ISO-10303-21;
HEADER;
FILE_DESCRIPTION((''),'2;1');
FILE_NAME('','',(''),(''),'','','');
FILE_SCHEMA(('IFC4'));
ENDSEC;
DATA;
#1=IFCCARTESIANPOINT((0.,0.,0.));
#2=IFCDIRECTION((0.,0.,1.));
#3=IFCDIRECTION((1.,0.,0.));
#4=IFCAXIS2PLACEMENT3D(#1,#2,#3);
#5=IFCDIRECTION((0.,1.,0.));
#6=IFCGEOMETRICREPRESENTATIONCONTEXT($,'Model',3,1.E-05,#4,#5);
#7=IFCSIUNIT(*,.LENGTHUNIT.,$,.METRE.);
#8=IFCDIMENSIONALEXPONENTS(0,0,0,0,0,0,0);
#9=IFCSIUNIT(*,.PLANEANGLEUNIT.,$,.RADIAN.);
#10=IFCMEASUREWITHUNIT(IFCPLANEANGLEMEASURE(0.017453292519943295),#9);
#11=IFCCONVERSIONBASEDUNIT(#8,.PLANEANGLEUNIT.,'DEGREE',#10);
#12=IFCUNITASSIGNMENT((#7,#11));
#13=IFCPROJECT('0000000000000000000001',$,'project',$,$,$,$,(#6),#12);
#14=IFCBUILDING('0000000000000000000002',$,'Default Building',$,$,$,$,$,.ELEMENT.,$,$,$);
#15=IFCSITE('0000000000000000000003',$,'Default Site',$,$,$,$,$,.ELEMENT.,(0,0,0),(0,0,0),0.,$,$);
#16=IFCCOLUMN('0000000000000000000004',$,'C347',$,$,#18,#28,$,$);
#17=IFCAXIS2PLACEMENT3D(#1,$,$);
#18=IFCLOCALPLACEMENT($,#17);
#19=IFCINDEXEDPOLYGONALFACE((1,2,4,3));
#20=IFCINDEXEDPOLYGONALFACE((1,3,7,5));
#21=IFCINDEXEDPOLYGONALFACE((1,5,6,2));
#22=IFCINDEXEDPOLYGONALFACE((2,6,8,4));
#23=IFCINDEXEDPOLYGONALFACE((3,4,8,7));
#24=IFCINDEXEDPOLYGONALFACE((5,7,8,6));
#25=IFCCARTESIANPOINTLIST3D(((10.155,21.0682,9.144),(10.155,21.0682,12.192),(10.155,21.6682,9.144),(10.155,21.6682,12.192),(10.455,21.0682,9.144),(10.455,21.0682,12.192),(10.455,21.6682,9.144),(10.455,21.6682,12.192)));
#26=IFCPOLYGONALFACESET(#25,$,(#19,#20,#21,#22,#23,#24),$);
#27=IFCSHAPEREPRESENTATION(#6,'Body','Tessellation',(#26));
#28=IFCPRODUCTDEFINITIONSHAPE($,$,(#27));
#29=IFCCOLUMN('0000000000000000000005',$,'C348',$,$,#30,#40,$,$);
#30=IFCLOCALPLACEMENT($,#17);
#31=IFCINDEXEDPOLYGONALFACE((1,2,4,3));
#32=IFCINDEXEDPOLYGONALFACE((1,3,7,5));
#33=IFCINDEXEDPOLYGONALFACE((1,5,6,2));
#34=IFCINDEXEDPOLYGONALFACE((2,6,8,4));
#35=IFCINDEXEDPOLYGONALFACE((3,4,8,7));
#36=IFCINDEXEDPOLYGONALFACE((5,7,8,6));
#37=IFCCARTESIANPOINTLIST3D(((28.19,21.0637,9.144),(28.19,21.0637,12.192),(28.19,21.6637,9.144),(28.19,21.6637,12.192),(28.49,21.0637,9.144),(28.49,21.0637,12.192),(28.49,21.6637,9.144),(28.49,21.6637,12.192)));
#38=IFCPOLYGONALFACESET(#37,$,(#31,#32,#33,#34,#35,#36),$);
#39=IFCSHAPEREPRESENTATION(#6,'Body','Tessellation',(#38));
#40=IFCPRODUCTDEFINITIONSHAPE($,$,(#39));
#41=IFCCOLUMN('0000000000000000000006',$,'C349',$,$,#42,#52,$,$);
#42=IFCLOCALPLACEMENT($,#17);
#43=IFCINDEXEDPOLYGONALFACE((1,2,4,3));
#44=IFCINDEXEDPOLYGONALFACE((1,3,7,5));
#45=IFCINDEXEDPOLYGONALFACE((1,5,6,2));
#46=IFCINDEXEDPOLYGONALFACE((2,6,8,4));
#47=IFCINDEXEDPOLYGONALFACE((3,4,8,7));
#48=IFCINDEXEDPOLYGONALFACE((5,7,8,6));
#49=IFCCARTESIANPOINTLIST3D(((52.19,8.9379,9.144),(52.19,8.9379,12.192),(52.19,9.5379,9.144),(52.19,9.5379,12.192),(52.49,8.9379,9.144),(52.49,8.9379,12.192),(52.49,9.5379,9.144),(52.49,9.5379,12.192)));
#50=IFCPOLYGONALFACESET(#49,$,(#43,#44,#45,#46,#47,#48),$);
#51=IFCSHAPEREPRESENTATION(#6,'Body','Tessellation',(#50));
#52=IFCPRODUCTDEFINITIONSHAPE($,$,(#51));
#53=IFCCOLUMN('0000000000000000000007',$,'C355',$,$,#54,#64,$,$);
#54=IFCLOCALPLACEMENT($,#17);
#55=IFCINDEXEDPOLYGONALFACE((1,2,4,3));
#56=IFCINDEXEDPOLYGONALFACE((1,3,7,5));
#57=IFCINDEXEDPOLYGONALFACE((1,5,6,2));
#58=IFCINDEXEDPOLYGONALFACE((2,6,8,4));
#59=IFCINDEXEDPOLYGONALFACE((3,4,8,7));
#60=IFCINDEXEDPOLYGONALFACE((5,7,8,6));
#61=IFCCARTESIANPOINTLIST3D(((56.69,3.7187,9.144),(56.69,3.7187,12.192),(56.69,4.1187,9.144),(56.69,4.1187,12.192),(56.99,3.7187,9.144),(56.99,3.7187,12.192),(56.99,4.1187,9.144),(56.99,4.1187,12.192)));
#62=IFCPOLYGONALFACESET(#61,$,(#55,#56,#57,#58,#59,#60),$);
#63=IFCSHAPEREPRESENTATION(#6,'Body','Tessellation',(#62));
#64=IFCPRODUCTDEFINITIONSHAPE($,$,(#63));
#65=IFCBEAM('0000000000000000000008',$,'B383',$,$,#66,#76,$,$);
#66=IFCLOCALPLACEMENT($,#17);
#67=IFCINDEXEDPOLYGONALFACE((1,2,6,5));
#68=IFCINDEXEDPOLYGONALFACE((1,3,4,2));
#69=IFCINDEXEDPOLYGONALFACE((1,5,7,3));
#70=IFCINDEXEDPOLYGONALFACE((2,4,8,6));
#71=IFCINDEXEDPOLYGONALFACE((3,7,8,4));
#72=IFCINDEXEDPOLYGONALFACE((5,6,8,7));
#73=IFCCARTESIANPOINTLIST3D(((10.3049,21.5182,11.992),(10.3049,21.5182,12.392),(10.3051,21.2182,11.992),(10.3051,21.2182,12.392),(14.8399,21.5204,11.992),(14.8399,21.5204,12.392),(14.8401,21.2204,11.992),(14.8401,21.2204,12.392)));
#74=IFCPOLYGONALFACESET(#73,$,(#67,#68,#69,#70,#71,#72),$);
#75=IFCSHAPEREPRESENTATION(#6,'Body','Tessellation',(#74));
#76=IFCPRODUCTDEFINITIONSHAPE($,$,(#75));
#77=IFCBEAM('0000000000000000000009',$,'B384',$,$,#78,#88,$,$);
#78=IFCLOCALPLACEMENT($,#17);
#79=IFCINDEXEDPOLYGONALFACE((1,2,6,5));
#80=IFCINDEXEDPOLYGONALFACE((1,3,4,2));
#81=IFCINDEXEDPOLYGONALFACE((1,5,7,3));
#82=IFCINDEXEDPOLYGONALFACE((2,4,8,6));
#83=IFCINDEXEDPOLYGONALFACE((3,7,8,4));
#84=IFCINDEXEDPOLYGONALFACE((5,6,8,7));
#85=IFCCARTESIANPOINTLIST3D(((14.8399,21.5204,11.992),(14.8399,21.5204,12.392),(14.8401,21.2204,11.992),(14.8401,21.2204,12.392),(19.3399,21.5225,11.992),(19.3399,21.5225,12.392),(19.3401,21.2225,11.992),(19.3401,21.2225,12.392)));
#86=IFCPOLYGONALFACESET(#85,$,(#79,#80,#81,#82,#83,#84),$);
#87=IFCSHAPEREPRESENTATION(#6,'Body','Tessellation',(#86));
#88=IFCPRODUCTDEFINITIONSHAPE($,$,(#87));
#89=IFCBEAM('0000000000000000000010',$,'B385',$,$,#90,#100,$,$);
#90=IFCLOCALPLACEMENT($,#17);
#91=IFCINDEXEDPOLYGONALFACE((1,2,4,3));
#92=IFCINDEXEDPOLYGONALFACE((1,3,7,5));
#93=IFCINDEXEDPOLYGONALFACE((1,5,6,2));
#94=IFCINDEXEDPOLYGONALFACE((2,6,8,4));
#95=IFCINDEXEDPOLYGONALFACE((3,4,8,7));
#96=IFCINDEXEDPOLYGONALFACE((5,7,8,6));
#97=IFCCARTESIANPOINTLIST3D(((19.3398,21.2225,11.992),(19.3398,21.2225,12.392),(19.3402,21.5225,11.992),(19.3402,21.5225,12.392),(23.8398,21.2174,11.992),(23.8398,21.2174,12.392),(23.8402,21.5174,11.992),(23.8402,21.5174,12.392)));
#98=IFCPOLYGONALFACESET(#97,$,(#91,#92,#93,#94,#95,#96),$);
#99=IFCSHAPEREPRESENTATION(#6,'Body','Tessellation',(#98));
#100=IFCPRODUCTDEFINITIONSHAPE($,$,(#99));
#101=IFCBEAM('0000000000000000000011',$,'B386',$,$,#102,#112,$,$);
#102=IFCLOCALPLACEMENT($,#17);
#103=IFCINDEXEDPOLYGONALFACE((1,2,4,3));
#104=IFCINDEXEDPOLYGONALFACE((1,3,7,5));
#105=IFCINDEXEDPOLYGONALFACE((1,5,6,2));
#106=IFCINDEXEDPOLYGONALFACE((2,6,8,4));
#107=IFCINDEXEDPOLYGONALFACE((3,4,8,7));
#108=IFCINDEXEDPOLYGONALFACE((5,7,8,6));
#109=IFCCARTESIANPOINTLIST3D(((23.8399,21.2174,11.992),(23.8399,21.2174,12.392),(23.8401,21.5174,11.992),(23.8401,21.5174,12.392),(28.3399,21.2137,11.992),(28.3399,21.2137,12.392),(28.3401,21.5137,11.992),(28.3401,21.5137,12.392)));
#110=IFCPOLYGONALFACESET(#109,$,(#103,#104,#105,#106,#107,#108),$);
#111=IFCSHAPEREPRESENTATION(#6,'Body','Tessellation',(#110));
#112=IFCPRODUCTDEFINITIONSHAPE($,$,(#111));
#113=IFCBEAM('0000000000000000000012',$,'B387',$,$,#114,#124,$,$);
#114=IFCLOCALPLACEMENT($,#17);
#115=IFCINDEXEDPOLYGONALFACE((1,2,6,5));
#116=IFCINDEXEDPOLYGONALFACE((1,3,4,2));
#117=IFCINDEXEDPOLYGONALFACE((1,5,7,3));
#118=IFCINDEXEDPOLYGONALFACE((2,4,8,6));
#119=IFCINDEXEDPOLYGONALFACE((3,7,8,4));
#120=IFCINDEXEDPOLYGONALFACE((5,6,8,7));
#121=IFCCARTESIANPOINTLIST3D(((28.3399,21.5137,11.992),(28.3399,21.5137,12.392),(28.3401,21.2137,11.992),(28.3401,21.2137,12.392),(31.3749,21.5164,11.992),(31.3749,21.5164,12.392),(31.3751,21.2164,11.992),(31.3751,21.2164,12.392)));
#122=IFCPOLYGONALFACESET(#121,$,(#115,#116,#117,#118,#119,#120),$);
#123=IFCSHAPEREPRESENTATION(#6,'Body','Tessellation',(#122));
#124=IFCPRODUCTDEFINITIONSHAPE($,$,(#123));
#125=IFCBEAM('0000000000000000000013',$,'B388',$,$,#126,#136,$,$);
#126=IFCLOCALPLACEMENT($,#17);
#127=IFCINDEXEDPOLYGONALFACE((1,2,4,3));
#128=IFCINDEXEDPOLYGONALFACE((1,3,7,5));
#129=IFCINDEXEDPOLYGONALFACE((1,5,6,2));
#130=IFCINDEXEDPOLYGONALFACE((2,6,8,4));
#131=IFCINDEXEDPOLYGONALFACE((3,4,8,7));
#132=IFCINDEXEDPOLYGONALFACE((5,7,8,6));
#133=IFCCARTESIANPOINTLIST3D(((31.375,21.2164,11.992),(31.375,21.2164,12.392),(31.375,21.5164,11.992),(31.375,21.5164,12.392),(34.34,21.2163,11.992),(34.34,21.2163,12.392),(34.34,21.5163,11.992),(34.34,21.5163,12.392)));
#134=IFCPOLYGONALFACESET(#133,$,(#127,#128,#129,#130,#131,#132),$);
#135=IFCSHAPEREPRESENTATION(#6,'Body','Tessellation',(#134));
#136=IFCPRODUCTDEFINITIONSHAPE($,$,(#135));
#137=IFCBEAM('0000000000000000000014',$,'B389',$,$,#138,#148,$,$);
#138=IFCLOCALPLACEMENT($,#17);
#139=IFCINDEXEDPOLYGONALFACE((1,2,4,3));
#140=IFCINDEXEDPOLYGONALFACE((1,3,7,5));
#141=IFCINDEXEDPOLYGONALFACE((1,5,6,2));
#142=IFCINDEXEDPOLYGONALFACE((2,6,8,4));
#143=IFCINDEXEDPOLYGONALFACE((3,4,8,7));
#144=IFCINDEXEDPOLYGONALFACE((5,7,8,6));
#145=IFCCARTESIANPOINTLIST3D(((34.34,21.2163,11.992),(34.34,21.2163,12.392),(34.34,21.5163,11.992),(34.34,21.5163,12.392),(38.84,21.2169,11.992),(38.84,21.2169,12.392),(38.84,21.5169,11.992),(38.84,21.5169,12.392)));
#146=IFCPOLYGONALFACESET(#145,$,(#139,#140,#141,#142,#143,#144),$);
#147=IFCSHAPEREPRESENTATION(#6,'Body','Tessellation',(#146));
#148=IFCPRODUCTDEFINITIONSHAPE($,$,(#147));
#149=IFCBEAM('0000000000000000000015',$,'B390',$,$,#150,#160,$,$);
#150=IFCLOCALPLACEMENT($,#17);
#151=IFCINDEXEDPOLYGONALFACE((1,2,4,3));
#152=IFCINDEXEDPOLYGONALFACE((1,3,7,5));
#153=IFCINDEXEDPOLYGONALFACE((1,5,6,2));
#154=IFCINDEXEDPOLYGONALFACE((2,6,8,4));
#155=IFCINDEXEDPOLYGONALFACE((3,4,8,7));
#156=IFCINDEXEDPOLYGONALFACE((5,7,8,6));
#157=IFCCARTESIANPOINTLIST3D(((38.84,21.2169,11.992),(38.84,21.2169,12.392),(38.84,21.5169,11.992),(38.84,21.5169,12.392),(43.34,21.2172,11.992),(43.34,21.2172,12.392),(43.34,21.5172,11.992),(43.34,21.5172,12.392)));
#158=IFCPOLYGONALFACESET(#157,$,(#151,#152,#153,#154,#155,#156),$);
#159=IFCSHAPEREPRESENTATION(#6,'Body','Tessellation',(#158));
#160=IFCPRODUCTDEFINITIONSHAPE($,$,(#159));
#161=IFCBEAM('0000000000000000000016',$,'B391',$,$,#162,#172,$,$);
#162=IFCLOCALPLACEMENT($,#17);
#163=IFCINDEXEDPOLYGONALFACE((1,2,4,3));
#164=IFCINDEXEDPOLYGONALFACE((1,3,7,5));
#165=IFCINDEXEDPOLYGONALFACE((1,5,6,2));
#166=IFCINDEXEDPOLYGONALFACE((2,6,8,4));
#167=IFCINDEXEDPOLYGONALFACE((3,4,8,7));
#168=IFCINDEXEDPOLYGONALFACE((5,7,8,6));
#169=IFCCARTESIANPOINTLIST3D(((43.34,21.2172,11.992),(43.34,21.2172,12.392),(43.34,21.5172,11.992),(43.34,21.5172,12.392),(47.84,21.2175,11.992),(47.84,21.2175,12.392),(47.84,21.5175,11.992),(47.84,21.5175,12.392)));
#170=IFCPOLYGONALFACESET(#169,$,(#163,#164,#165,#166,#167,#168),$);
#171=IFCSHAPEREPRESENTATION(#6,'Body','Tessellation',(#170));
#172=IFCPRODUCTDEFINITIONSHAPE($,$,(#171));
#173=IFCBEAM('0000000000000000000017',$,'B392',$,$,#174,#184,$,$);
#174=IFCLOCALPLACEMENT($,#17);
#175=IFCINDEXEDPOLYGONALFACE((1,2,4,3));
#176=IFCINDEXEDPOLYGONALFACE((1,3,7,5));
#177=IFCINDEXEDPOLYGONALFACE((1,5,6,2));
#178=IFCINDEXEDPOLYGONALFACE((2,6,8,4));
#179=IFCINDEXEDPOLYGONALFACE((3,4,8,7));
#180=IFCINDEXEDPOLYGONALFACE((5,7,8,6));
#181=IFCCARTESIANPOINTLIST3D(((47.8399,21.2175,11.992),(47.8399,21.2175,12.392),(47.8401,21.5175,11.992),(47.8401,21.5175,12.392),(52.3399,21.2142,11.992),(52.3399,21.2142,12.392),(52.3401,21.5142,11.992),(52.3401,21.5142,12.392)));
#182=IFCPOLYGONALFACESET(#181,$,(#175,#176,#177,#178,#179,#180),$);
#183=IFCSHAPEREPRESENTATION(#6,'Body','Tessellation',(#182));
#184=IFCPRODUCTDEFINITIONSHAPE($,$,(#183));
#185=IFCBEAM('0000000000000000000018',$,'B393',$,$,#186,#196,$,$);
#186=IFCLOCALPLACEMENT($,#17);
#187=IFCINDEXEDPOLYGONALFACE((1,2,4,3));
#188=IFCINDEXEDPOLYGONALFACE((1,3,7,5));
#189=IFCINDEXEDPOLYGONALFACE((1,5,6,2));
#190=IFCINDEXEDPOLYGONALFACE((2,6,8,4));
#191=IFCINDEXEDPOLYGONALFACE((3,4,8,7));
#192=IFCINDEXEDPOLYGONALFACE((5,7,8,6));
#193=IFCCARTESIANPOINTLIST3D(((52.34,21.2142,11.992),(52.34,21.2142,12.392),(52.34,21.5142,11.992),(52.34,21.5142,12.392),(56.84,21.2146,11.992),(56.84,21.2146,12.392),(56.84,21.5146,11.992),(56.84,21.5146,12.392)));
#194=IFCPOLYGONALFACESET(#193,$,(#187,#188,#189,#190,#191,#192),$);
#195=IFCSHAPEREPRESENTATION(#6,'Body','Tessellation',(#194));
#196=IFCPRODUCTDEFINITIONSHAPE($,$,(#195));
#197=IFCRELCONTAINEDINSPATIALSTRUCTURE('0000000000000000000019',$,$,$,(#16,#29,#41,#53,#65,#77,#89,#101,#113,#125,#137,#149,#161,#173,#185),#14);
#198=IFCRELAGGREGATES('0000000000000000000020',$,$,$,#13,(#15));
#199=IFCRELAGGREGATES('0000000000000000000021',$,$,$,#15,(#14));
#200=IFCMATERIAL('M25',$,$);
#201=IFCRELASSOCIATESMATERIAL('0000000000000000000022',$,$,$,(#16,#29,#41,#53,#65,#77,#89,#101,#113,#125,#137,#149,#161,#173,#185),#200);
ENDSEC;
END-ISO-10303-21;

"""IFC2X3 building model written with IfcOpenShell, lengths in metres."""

from ifc_helpers import new_model, entity, si_unit, converted_unit, direction, frame, frame_2d, origin_with_axes, place, context, project, spatial, rectangle, extrude, material, element, save


model = new_model("IFC2X3")

# Units and contexts
model_context = context("Model", 3, precision=1e-05, world=origin_with_axes(), true_north=direction((0.0, 1.0, 0.0)))
ifc_project = project(units=[si_unit("LENGTHUNIT", "METRE"), converted_unit("PLANEANGLEUNIT", "DEGREE", entity("IfcPlaneAngleMeasure", 0.017453292519943295), si_unit("PLANEANGLEUNIT", "RADIAN"), dimensions=[0, 0, 0, 0, 0, 0, 0])], contexts=[model_context])

# Site, building
site = spatial("IfcSite", under=ifc_project, Name="Default Site", CompositionType="ELEMENT", RefLatitude=(0, 0, 0), RefLongitude=(0, 0, 0), RefElevation=0.0)
building = spatial("IfcBuilding", under=site, Name="Default Building", CompositionType="ELEMENT")

# Columns
ifc_material = material(Name="M25")
placement = place(None, origin_with_axes())
element("IfcColumn", 1, at=placement, inside=building, material=ifc_material, Name="C347", context=model_context, shape_type="SweptSolid", body=[
    extrude(rectangle(XDim=0.3, YDim=0.6, at=frame_2d((0.0, 0.0), x_axis=(1.0, 0.0, 0.0))), frame((10.305, 21.3682, 9.144), z_axis=(0.0, 0.0, 1.0), x_axis=(1.0, 0.0, 0.0)), (0.0, 0.0, 1.0), 3.048),
])
element("IfcColumn", 2, at=placement, inside=building, material=ifc_material, Name="C348", context=model_context, shape_type="SweptSolid", body=[
    extrude(rectangle(XDim=0.3, YDim=0.6, at=frame_2d((0.0, 0.0), x_axis=(1.0, 0.0, 0.0))), frame((28.34, 21.3637, 9.144), z_axis=(0.0, 0.0, 1.0), x_axis=(1.0, 0.0, 0.0)), (0.0, 0.0, 1.0), 3.048),
])
element("IfcColumn", 3, at=placement, inside=building, material=ifc_material, Name="C349", context=model_context, shape_type="SweptSolid", body=[
    extrude(rectangle(XDim=0.3, YDim=0.6, at=frame_2d((0.0, 0.0), x_axis=(1.0, 0.0, 0.0))), frame((52.34, 9.2379, 9.144), z_axis=(0.0, 0.0, 1.0), x_axis=(1.0, 0.0, 0.0)), (0.0, 0.0, 1.0), 3.048),
])
element("IfcColumn", 4, at=placement, inside=building, material=ifc_material, Name="C355", context=model_context, shape_type="SweptSolid", body=[
    extrude(rectangle(XDim=0.3, YDim=0.4, at=frame_2d((0.0, 0.0), x_axis=(1.0, 0.0, 0.0))), frame((56.84, 3.9187, 9.144), z_axis=(0.0, 0.0, 1.0), x_axis=(1.0, 0.0, 0.0)), (0.0, 0.0, 1.0), 3.048),
])

# Beams
element("IfcBeam", 5, at=placement, inside=building, material=ifc_material, Name="B383", context=model_context, shape_type="SweptSolid", body=[
    extrude(rectangle(XDim=0.3, YDim=0.4, at=frame_2d((0.0, 0.0), x_axis=(0.0, 1.0, 0.0))), frame((10.305, 21.3682, 12.192), z_axis=(1.0, 0.000476, 0.0), x_axis=(0.0, 0.0, -1.0)), (0.0, 0.0, 1.0), 4.535),
])
element("IfcBeam", 6, at=placement, inside=building, material=ifc_material, Name="B384", context=model_context, shape_type="SweptSolid", body=[
    extrude(rectangle(XDim=0.3, YDim=0.4, at=frame_2d((0.0, 0.0), x_axis=(0.0, 1.0, 0.0))), frame((14.84, 21.3704, 12.192), z_axis=(1.0, 0.000471, 0.0), x_axis=(0.0, 0.0, -1.0)), (0.0, 0.0, 1.0), 4.5),
])
element("IfcBeam", 7, at=placement, inside=building, material=ifc_material, Name="B385", context=model_context, shape_type="SweptSolid", body=[
    extrude(rectangle(XDim=0.3, YDim=0.4, at=frame_2d((0.0, 0.0), x_axis=(0.0, 1.0, 0.0))), frame((19.34, 21.3725, 12.192), z_axis=(0.999999, -0.001141, 0.0), x_axis=(0.0, 0.0, -1.0)), (0.0, 0.0, 1.0), 4.5),
])
element("IfcBeam", 8, at=placement, inside=building, material=ifc_material, Name="B386", context=model_context, shape_type="SweptSolid", body=[
    extrude(rectangle(XDim=0.3, YDim=0.4, at=frame_2d((0.0, 0.0), x_axis=(0.0, 1.0, 0.0))), frame((23.84, 21.3674, 12.192), z_axis=(1.0, -0.000812, 0.0), x_axis=(0.0, 0.0, -1.0)), (0.0, 0.0, 1.0), 4.5),
])
element("IfcBeam", 9, at=placement, inside=building, material=ifc_material, Name="B387", context=model_context, shape_type="SweptSolid", body=[
    extrude(rectangle(XDim=0.3, YDim=0.4, at=frame_2d((0.0, 0.0), x_axis=(0.0, 1.0, 0.0))), frame((28.34, 21.3637, 12.192), z_axis=(1.0, 0.000883, 0.0), x_axis=(0.0, 0.0, -1.0)), (0.0, 0.0, 1.0), 3.035),
])
element("IfcBeam", 10, at=placement, inside=building, material=ifc_material, Name="B388", context=model_context, shape_type="SweptSolid", body=[
    extrude(rectangle(XDim=0.3, YDim=0.4, at=frame_2d((0.0, 0.0), x_axis=(0.0, 1.0, 0.0))), frame((31.375, 21.3664, 12.192), z_axis=(1.0, -0.000016, 0.0), x_axis=(0.0, 0.0, -1.0)), (0.0, 0.0, 1.0), 2.965),
])
element("IfcBeam", 11, at=placement, inside=building, material=ifc_material, Name="B389", context=model_context, shape_type="SweptSolid", body=[
    extrude(rectangle(XDim=0.3, YDim=0.4, at=frame_2d((0.0, 0.0), x_axis=(0.0, 1.0, 0.0))), frame((34.34, 21.3663, 12.192), z_axis=(1.0, 0.000136, 0.0), x_axis=(0.0, 0.0, -1.0)), (0.0, 0.0, 1.0), 4.5),
])
element("IfcBeam", 12, at=placement, inside=building, material=ifc_material, Name="B390", context=model_context, shape_type="SweptSolid", body=[
    extrude(rectangle(XDim=0.3, YDim=0.4, at=frame_2d((0.0, 0.0), x_axis=(0.0, 1.0, 0.0))), frame((38.84, 21.3669, 12.192), z_axis=(1.0, 0.00005, 0.0), x_axis=(0.0, 0.0, -1.0)), (0.0, 0.0, 1.0), 4.5),
])
element("IfcBeam", 13, at=placement, inside=building, material=ifc_material, Name="B391", context=model_context, shape_type="SweptSolid", body=[
    extrude(rectangle(XDim=0.3, YDim=0.4, at=frame_2d((0.0, 0.0), x_axis=(0.0, 1.0, 0.0))), frame((43.34, 21.3672, 12.192), z_axis=(1.0, 0.000075, 0.0), x_axis=(0.0, 0.0, -1.0)), (0.0, 0.0, 1.0), 4.5),
])
element("IfcBeam", 14, at=placement, inside=building, material=ifc_material, Name="B392", context=model_context, shape_type="SweptSolid", body=[
    extrude(rectangle(XDim=0.3, YDim=0.4, at=frame_2d((0.0, 0.0), x_axis=(0.0, 1.0, 0.0))), frame((47.84, 21.3675, 12.192), z_axis=(1.0, -0.000744, 0.0), x_axis=(0.0, 0.0, -1.0)), (0.0, 0.0, 1.0), 4.5),
])
element("IfcBeam", 15, at=placement, inside=building, material=ifc_material, Name="B393", context=model_context, shape_type="SweptSolid", body=[
    extrude(rectangle(XDim=0.3, YDim=0.4, at=frame_2d((0.0, 0.0), x_axis=(0.0, 1.0, 0.0))), frame((52.34, 21.3642, 12.192), z_axis=(1.0, 0.000102, 0.0), x_axis=(0.0, 0.0, -1.0)), (0.0, 0.0, 1.0), 4.5),
])

save(model, "model.ifc")
